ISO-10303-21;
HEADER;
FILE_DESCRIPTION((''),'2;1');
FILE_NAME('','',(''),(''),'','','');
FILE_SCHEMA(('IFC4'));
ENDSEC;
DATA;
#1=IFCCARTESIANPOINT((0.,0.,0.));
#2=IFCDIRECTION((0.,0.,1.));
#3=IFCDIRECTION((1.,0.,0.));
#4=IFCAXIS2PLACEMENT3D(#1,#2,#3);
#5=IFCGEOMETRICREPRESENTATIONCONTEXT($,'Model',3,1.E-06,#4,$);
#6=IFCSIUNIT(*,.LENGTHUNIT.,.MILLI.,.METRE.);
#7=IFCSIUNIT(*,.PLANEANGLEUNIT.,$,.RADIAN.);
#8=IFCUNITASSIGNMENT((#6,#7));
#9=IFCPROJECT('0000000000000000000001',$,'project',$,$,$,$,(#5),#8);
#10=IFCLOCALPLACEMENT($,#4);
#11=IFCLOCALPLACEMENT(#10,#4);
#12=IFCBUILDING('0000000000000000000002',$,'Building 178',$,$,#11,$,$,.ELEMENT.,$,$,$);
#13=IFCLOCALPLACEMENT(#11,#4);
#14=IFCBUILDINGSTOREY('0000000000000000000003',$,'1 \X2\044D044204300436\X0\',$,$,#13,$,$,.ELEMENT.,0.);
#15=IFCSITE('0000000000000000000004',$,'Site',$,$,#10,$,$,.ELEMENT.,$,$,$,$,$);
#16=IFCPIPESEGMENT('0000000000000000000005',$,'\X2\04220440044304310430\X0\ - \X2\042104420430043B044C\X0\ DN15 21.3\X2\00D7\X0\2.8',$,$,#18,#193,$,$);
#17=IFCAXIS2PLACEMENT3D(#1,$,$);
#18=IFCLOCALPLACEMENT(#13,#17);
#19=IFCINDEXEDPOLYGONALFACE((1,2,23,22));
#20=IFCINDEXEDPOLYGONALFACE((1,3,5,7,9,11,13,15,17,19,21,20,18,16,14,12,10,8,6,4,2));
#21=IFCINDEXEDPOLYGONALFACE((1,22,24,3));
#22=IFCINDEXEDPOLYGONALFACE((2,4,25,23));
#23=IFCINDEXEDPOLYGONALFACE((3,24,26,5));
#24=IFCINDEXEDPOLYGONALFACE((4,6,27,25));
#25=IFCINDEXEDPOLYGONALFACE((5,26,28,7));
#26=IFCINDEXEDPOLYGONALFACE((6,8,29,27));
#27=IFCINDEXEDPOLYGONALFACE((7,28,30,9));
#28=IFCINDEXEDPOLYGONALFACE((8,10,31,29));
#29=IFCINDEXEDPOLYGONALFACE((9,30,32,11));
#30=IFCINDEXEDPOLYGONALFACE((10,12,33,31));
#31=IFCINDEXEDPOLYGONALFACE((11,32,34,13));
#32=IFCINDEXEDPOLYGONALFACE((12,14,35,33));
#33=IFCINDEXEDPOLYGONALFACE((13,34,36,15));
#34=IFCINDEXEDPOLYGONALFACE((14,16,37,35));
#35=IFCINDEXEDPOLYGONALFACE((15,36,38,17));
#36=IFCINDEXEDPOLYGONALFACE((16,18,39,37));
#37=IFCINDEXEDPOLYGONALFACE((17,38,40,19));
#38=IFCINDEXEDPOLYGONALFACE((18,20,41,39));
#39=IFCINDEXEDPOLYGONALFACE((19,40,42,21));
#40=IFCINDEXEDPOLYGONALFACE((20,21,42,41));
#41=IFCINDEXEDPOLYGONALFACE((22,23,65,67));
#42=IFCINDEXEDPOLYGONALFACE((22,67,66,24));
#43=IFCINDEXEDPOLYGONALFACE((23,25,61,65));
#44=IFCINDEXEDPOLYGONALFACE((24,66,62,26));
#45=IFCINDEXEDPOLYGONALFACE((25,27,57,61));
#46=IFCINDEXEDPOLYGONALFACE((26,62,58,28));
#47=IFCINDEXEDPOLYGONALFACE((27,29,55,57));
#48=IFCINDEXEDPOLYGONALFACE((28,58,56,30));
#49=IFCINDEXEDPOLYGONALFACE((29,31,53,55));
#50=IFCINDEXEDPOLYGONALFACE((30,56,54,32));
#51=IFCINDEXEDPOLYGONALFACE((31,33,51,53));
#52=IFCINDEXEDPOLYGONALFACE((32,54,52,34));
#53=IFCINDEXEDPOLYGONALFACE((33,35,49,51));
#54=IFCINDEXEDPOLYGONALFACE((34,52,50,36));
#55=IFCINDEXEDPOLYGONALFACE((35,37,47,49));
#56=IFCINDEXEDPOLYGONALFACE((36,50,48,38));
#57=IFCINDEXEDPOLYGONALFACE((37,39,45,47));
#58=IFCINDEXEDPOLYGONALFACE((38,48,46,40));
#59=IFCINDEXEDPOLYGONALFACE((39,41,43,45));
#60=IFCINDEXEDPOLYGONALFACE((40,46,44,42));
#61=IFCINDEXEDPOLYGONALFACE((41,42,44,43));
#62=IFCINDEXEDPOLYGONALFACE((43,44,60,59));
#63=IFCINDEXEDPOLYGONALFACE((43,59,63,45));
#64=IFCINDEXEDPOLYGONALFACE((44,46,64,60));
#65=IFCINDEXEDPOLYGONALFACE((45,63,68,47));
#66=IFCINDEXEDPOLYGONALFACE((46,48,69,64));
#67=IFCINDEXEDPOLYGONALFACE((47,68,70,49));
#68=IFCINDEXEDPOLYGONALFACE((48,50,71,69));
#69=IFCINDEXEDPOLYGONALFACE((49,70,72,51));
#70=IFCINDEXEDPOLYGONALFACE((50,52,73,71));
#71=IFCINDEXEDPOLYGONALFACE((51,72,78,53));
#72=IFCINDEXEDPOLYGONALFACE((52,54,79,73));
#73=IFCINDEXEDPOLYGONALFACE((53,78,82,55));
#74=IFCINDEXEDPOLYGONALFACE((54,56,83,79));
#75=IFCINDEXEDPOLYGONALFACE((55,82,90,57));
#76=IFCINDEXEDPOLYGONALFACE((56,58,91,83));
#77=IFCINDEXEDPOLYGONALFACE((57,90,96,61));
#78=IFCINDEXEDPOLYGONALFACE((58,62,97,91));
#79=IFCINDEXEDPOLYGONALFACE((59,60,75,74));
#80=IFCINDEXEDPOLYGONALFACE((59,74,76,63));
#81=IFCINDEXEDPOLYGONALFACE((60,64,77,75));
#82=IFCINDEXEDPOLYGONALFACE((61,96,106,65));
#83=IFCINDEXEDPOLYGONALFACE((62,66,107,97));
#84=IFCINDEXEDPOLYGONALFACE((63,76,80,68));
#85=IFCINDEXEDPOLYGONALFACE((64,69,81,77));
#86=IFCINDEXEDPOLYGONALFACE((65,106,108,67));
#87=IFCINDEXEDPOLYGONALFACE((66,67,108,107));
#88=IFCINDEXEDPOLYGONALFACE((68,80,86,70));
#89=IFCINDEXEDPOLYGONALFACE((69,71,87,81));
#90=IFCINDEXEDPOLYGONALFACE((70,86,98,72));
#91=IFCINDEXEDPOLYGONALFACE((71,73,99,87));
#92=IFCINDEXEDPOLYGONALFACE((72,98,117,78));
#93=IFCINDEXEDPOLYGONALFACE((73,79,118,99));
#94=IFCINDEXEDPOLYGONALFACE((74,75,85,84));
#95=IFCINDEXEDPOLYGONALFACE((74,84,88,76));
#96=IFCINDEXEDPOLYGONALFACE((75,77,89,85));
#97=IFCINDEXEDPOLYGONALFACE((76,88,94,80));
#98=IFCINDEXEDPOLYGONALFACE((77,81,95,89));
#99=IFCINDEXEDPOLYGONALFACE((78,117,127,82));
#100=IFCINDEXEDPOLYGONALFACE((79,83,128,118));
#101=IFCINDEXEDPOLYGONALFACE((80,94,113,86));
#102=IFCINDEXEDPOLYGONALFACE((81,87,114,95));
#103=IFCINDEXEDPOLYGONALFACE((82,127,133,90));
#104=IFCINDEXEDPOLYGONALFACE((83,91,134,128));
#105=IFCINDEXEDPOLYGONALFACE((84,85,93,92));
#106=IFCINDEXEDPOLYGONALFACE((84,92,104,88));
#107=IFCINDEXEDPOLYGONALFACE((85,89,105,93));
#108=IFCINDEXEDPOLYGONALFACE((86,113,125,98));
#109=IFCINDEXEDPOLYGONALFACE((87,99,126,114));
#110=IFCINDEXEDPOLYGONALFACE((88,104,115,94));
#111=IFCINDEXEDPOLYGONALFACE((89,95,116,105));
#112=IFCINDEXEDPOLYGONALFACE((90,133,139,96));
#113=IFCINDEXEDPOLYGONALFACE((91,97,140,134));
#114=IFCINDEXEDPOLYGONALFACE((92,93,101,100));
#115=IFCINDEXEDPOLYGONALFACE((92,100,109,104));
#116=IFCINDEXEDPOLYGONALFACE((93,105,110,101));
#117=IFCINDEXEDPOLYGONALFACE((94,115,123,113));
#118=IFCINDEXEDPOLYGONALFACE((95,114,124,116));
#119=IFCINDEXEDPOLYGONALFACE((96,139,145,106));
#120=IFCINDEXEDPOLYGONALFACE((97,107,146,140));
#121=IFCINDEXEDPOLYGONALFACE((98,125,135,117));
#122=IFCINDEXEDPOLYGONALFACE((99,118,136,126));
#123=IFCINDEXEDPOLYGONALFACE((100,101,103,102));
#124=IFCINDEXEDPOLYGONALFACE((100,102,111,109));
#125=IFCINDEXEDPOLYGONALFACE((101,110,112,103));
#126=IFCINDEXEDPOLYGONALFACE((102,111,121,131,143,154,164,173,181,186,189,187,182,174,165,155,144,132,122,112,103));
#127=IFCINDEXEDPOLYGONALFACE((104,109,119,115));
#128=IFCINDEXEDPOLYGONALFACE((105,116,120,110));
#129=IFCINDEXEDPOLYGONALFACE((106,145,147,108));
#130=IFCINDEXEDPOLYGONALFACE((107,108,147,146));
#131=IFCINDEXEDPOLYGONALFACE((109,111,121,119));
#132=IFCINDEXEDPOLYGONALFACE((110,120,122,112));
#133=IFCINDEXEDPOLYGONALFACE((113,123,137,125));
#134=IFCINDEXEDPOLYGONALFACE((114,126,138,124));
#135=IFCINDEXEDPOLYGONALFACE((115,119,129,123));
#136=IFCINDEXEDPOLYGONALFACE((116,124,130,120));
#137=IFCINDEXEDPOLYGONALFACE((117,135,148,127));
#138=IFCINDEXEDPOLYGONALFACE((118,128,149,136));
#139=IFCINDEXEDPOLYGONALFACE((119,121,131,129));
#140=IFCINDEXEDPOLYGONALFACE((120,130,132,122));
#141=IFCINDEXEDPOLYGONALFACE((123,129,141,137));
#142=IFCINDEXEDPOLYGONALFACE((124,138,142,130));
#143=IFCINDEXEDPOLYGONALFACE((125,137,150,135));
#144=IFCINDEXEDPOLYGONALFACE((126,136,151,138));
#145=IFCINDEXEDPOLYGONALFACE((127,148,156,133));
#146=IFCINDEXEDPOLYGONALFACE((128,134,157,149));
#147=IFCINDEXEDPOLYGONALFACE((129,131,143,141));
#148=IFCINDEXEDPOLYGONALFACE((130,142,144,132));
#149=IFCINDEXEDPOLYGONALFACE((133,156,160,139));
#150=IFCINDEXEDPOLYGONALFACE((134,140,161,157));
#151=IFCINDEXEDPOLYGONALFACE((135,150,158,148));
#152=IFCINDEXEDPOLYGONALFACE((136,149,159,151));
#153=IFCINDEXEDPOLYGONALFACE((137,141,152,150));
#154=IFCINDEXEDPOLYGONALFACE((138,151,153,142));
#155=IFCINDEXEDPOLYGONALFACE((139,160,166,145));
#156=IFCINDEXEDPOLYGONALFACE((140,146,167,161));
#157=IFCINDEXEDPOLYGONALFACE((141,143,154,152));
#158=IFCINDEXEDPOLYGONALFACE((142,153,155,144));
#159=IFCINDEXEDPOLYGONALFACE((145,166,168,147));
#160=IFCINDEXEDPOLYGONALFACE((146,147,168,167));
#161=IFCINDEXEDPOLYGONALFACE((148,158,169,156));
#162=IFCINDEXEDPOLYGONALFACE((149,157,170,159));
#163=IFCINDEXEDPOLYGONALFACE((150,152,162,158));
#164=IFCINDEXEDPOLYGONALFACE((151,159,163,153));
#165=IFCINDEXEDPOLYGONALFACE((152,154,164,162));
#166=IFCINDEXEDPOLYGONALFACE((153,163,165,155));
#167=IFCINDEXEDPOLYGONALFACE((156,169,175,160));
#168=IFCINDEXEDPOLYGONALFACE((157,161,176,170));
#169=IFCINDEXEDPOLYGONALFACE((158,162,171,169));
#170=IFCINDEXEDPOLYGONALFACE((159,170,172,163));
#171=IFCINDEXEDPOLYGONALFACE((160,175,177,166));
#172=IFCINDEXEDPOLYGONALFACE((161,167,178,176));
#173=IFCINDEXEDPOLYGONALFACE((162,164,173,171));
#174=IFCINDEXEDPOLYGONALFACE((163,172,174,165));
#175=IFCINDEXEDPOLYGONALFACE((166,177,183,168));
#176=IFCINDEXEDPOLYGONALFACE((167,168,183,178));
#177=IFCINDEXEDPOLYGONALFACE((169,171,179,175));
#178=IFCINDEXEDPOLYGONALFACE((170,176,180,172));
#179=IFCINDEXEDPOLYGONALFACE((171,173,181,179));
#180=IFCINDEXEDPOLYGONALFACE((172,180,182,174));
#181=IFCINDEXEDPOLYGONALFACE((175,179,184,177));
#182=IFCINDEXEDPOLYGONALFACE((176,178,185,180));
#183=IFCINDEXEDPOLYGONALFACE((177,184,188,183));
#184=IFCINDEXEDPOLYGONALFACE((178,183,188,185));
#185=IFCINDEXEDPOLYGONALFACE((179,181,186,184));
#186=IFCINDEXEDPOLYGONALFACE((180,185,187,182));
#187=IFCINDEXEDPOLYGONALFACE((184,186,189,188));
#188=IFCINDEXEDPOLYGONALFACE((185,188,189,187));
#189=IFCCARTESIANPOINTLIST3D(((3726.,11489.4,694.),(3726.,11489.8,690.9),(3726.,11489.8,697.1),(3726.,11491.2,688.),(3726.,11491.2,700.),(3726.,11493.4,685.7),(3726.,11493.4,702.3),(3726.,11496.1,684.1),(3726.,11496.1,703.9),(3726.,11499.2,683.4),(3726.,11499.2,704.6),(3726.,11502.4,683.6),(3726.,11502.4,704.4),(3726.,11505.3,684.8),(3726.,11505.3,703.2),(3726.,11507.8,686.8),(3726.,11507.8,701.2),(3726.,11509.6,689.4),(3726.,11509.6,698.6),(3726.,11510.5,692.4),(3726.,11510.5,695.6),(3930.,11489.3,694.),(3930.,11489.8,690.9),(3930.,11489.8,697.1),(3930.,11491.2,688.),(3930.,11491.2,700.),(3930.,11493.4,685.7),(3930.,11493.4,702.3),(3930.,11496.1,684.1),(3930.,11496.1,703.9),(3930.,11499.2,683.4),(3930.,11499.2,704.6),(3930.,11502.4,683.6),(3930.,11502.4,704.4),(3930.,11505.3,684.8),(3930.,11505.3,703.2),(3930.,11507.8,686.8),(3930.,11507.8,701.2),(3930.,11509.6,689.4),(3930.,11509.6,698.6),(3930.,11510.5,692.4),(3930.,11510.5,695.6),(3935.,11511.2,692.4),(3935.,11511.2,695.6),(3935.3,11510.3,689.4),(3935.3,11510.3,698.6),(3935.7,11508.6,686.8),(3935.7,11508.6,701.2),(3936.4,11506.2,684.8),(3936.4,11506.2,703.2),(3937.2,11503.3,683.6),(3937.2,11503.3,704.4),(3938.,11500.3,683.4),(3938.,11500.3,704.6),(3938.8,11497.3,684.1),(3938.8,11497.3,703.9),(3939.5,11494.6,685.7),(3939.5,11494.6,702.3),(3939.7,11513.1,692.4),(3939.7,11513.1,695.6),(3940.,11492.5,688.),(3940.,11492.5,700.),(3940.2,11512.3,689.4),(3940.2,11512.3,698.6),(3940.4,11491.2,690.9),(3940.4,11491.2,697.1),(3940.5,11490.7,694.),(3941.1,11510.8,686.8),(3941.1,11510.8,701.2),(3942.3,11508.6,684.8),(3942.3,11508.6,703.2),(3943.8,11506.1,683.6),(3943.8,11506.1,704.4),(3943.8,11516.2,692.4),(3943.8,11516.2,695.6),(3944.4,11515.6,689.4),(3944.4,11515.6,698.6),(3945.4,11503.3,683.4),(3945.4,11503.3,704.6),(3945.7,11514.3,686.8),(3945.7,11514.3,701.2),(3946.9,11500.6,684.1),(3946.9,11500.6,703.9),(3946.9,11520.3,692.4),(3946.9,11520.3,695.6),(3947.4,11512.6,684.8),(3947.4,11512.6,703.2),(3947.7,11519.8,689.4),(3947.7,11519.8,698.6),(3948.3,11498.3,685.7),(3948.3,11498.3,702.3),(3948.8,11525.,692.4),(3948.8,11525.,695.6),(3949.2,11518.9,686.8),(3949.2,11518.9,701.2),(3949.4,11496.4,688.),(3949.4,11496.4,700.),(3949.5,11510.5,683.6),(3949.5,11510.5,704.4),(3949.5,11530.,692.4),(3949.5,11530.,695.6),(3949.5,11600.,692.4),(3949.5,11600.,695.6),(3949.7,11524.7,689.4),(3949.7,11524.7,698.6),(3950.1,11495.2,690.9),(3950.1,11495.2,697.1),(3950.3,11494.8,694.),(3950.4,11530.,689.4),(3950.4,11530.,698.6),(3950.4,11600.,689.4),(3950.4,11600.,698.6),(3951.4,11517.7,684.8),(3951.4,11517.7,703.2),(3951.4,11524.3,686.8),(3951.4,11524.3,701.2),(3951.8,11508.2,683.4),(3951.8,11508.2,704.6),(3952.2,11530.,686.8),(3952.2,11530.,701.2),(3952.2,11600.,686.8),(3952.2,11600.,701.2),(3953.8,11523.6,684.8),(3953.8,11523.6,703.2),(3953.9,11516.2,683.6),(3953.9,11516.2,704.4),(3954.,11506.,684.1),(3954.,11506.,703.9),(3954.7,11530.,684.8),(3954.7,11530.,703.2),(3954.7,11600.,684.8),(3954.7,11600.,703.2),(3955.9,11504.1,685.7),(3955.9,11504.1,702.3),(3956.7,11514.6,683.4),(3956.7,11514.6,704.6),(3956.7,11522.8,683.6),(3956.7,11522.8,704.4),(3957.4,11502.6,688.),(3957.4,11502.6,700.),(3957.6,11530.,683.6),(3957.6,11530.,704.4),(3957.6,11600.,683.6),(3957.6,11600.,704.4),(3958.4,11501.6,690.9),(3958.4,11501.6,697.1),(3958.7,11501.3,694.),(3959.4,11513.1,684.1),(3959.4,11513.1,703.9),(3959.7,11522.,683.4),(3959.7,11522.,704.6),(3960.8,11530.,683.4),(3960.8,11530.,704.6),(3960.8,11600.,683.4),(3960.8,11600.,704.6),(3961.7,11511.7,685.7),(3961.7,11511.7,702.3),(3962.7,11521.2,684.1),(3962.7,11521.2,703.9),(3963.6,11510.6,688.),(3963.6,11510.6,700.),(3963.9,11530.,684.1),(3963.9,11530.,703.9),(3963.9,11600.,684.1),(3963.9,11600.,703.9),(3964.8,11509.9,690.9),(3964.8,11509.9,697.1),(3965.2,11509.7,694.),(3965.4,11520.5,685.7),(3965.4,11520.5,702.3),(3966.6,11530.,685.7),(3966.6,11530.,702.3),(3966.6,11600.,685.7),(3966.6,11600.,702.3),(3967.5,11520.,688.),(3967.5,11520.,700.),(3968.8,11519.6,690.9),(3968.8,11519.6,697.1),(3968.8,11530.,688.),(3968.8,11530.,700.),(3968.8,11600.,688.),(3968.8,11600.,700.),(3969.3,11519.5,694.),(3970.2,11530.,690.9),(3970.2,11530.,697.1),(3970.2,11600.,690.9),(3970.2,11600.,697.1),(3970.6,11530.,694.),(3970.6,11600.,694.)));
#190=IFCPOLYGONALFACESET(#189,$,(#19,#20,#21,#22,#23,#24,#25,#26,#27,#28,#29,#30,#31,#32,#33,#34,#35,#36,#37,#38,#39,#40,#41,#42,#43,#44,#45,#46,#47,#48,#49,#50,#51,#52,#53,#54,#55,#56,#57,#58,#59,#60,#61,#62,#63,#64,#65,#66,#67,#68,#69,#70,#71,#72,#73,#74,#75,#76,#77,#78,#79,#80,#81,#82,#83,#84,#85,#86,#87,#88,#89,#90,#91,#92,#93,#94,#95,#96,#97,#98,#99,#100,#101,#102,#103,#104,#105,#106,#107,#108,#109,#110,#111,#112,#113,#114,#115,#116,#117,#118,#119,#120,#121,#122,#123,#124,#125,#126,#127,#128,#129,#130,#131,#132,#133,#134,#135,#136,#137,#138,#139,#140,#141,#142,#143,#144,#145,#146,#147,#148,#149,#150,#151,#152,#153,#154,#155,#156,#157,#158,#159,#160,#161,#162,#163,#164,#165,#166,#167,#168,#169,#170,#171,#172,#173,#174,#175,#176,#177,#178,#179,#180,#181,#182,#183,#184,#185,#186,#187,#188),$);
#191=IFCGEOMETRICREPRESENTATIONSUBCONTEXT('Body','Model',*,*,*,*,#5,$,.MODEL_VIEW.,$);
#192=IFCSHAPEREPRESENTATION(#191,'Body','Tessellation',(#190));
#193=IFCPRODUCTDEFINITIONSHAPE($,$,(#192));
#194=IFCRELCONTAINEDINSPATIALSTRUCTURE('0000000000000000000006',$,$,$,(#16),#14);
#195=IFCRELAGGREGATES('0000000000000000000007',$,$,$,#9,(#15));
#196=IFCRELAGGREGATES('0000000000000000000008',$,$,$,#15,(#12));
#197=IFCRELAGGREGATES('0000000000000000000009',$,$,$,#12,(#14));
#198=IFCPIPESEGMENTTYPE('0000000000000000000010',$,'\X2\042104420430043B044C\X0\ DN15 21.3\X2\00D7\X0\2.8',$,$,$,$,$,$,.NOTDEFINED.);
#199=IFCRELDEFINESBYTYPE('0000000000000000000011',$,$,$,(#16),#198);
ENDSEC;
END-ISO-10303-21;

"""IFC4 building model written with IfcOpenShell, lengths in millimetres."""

from ifc_helpers import new_model, entity, si_unit, frame, origin_with_axes, place, context, subcontext, project, spatial, source, transform, mapped, type_object, element, save


model = new_model("IFC4")

# Units and contexts
model_context = context("Model", 3, precision=1e-06, world=origin_with_axes())
body_context = subcontext(model_context, "Body", "Model", "MODEL_VIEW")
ifc_project = project(units=[si_unit("LENGTHUNIT", "METRE", prefix="MILLI"), si_unit("PLANEANGLEUNIT", "RADIAN")], contexts=[model_context])

# Site, building, storey
site_placement = place(None, origin_with_axes())
site = spatial("IfcSite", under=ifc_project, at=site_placement, Name="Site", CompositionType="ELEMENT")
building_placement = place(site_placement, origin_with_axes())
building = spatial("IfcBuilding", under=site, at=building_placement, Name="Building 178", CompositionType="ELEMENT")
storey_placement = place(building_placement, origin_with_axes())
storey = spatial("IfcBuildingStorey", under=building, at=storey_placement, Name="1 этаж", CompositionType="ELEMENT", Elevation=0.0)

# Pipe segment
pipe_segment_type = type_object("IfcPipeSegmentType", Name="Сталь DN15 21.3×2.8", PredefinedType="NOTDEFINED")
shared_shape_1 = source(origin_with_axes(), body_context, "Body", "AdvancedSweptSolid", [
    entity("IfcSweptDiskSolid", entity("IfcIndexedPolyCurve", entity("IfcCartesianPointList3D", [[0.0, 0.0, 0.0], [0.0, 0.0, -70.0], [8.8, 0.0, -91.2], [30.0, 0.0, -100.0], [234.0, 0.0, -100.0]]), [entity("IfcLineIndex", [1, 2]), entity("IfcArcIndex", [2, 3, 4]), entity("IfcLineIndex", [4, 5])]), 10.7),
])
for number, where, z_axis, x_axis, name in (
    (1, (3960.0, 11600.0, 694.0), (0.0, 1.0, 0.0), (-1.0, 0.0, 0.0), "Труба - Сталь DN15 21.3×2.8"),
):
    element("IfcPipeSegment", number, at=place(storey_placement, frame(where, z_axis=z_axis, x_axis=x_axis)), inside=storey, type_object=pipe_segment_type, Name=name, context=body_context, shape_type="MappedRepresentation", body=[
        mapped(shared_shape_1, transform((0.0, 0.0, 0.0), x_axis=(1.0, 0.0, 0.0), y_axis=(0.0, 1.0, 0.0), z_axis=(0.0, 0.0, 1.0), scale=1.0)),
    ])

save(model, "model.ifc")
